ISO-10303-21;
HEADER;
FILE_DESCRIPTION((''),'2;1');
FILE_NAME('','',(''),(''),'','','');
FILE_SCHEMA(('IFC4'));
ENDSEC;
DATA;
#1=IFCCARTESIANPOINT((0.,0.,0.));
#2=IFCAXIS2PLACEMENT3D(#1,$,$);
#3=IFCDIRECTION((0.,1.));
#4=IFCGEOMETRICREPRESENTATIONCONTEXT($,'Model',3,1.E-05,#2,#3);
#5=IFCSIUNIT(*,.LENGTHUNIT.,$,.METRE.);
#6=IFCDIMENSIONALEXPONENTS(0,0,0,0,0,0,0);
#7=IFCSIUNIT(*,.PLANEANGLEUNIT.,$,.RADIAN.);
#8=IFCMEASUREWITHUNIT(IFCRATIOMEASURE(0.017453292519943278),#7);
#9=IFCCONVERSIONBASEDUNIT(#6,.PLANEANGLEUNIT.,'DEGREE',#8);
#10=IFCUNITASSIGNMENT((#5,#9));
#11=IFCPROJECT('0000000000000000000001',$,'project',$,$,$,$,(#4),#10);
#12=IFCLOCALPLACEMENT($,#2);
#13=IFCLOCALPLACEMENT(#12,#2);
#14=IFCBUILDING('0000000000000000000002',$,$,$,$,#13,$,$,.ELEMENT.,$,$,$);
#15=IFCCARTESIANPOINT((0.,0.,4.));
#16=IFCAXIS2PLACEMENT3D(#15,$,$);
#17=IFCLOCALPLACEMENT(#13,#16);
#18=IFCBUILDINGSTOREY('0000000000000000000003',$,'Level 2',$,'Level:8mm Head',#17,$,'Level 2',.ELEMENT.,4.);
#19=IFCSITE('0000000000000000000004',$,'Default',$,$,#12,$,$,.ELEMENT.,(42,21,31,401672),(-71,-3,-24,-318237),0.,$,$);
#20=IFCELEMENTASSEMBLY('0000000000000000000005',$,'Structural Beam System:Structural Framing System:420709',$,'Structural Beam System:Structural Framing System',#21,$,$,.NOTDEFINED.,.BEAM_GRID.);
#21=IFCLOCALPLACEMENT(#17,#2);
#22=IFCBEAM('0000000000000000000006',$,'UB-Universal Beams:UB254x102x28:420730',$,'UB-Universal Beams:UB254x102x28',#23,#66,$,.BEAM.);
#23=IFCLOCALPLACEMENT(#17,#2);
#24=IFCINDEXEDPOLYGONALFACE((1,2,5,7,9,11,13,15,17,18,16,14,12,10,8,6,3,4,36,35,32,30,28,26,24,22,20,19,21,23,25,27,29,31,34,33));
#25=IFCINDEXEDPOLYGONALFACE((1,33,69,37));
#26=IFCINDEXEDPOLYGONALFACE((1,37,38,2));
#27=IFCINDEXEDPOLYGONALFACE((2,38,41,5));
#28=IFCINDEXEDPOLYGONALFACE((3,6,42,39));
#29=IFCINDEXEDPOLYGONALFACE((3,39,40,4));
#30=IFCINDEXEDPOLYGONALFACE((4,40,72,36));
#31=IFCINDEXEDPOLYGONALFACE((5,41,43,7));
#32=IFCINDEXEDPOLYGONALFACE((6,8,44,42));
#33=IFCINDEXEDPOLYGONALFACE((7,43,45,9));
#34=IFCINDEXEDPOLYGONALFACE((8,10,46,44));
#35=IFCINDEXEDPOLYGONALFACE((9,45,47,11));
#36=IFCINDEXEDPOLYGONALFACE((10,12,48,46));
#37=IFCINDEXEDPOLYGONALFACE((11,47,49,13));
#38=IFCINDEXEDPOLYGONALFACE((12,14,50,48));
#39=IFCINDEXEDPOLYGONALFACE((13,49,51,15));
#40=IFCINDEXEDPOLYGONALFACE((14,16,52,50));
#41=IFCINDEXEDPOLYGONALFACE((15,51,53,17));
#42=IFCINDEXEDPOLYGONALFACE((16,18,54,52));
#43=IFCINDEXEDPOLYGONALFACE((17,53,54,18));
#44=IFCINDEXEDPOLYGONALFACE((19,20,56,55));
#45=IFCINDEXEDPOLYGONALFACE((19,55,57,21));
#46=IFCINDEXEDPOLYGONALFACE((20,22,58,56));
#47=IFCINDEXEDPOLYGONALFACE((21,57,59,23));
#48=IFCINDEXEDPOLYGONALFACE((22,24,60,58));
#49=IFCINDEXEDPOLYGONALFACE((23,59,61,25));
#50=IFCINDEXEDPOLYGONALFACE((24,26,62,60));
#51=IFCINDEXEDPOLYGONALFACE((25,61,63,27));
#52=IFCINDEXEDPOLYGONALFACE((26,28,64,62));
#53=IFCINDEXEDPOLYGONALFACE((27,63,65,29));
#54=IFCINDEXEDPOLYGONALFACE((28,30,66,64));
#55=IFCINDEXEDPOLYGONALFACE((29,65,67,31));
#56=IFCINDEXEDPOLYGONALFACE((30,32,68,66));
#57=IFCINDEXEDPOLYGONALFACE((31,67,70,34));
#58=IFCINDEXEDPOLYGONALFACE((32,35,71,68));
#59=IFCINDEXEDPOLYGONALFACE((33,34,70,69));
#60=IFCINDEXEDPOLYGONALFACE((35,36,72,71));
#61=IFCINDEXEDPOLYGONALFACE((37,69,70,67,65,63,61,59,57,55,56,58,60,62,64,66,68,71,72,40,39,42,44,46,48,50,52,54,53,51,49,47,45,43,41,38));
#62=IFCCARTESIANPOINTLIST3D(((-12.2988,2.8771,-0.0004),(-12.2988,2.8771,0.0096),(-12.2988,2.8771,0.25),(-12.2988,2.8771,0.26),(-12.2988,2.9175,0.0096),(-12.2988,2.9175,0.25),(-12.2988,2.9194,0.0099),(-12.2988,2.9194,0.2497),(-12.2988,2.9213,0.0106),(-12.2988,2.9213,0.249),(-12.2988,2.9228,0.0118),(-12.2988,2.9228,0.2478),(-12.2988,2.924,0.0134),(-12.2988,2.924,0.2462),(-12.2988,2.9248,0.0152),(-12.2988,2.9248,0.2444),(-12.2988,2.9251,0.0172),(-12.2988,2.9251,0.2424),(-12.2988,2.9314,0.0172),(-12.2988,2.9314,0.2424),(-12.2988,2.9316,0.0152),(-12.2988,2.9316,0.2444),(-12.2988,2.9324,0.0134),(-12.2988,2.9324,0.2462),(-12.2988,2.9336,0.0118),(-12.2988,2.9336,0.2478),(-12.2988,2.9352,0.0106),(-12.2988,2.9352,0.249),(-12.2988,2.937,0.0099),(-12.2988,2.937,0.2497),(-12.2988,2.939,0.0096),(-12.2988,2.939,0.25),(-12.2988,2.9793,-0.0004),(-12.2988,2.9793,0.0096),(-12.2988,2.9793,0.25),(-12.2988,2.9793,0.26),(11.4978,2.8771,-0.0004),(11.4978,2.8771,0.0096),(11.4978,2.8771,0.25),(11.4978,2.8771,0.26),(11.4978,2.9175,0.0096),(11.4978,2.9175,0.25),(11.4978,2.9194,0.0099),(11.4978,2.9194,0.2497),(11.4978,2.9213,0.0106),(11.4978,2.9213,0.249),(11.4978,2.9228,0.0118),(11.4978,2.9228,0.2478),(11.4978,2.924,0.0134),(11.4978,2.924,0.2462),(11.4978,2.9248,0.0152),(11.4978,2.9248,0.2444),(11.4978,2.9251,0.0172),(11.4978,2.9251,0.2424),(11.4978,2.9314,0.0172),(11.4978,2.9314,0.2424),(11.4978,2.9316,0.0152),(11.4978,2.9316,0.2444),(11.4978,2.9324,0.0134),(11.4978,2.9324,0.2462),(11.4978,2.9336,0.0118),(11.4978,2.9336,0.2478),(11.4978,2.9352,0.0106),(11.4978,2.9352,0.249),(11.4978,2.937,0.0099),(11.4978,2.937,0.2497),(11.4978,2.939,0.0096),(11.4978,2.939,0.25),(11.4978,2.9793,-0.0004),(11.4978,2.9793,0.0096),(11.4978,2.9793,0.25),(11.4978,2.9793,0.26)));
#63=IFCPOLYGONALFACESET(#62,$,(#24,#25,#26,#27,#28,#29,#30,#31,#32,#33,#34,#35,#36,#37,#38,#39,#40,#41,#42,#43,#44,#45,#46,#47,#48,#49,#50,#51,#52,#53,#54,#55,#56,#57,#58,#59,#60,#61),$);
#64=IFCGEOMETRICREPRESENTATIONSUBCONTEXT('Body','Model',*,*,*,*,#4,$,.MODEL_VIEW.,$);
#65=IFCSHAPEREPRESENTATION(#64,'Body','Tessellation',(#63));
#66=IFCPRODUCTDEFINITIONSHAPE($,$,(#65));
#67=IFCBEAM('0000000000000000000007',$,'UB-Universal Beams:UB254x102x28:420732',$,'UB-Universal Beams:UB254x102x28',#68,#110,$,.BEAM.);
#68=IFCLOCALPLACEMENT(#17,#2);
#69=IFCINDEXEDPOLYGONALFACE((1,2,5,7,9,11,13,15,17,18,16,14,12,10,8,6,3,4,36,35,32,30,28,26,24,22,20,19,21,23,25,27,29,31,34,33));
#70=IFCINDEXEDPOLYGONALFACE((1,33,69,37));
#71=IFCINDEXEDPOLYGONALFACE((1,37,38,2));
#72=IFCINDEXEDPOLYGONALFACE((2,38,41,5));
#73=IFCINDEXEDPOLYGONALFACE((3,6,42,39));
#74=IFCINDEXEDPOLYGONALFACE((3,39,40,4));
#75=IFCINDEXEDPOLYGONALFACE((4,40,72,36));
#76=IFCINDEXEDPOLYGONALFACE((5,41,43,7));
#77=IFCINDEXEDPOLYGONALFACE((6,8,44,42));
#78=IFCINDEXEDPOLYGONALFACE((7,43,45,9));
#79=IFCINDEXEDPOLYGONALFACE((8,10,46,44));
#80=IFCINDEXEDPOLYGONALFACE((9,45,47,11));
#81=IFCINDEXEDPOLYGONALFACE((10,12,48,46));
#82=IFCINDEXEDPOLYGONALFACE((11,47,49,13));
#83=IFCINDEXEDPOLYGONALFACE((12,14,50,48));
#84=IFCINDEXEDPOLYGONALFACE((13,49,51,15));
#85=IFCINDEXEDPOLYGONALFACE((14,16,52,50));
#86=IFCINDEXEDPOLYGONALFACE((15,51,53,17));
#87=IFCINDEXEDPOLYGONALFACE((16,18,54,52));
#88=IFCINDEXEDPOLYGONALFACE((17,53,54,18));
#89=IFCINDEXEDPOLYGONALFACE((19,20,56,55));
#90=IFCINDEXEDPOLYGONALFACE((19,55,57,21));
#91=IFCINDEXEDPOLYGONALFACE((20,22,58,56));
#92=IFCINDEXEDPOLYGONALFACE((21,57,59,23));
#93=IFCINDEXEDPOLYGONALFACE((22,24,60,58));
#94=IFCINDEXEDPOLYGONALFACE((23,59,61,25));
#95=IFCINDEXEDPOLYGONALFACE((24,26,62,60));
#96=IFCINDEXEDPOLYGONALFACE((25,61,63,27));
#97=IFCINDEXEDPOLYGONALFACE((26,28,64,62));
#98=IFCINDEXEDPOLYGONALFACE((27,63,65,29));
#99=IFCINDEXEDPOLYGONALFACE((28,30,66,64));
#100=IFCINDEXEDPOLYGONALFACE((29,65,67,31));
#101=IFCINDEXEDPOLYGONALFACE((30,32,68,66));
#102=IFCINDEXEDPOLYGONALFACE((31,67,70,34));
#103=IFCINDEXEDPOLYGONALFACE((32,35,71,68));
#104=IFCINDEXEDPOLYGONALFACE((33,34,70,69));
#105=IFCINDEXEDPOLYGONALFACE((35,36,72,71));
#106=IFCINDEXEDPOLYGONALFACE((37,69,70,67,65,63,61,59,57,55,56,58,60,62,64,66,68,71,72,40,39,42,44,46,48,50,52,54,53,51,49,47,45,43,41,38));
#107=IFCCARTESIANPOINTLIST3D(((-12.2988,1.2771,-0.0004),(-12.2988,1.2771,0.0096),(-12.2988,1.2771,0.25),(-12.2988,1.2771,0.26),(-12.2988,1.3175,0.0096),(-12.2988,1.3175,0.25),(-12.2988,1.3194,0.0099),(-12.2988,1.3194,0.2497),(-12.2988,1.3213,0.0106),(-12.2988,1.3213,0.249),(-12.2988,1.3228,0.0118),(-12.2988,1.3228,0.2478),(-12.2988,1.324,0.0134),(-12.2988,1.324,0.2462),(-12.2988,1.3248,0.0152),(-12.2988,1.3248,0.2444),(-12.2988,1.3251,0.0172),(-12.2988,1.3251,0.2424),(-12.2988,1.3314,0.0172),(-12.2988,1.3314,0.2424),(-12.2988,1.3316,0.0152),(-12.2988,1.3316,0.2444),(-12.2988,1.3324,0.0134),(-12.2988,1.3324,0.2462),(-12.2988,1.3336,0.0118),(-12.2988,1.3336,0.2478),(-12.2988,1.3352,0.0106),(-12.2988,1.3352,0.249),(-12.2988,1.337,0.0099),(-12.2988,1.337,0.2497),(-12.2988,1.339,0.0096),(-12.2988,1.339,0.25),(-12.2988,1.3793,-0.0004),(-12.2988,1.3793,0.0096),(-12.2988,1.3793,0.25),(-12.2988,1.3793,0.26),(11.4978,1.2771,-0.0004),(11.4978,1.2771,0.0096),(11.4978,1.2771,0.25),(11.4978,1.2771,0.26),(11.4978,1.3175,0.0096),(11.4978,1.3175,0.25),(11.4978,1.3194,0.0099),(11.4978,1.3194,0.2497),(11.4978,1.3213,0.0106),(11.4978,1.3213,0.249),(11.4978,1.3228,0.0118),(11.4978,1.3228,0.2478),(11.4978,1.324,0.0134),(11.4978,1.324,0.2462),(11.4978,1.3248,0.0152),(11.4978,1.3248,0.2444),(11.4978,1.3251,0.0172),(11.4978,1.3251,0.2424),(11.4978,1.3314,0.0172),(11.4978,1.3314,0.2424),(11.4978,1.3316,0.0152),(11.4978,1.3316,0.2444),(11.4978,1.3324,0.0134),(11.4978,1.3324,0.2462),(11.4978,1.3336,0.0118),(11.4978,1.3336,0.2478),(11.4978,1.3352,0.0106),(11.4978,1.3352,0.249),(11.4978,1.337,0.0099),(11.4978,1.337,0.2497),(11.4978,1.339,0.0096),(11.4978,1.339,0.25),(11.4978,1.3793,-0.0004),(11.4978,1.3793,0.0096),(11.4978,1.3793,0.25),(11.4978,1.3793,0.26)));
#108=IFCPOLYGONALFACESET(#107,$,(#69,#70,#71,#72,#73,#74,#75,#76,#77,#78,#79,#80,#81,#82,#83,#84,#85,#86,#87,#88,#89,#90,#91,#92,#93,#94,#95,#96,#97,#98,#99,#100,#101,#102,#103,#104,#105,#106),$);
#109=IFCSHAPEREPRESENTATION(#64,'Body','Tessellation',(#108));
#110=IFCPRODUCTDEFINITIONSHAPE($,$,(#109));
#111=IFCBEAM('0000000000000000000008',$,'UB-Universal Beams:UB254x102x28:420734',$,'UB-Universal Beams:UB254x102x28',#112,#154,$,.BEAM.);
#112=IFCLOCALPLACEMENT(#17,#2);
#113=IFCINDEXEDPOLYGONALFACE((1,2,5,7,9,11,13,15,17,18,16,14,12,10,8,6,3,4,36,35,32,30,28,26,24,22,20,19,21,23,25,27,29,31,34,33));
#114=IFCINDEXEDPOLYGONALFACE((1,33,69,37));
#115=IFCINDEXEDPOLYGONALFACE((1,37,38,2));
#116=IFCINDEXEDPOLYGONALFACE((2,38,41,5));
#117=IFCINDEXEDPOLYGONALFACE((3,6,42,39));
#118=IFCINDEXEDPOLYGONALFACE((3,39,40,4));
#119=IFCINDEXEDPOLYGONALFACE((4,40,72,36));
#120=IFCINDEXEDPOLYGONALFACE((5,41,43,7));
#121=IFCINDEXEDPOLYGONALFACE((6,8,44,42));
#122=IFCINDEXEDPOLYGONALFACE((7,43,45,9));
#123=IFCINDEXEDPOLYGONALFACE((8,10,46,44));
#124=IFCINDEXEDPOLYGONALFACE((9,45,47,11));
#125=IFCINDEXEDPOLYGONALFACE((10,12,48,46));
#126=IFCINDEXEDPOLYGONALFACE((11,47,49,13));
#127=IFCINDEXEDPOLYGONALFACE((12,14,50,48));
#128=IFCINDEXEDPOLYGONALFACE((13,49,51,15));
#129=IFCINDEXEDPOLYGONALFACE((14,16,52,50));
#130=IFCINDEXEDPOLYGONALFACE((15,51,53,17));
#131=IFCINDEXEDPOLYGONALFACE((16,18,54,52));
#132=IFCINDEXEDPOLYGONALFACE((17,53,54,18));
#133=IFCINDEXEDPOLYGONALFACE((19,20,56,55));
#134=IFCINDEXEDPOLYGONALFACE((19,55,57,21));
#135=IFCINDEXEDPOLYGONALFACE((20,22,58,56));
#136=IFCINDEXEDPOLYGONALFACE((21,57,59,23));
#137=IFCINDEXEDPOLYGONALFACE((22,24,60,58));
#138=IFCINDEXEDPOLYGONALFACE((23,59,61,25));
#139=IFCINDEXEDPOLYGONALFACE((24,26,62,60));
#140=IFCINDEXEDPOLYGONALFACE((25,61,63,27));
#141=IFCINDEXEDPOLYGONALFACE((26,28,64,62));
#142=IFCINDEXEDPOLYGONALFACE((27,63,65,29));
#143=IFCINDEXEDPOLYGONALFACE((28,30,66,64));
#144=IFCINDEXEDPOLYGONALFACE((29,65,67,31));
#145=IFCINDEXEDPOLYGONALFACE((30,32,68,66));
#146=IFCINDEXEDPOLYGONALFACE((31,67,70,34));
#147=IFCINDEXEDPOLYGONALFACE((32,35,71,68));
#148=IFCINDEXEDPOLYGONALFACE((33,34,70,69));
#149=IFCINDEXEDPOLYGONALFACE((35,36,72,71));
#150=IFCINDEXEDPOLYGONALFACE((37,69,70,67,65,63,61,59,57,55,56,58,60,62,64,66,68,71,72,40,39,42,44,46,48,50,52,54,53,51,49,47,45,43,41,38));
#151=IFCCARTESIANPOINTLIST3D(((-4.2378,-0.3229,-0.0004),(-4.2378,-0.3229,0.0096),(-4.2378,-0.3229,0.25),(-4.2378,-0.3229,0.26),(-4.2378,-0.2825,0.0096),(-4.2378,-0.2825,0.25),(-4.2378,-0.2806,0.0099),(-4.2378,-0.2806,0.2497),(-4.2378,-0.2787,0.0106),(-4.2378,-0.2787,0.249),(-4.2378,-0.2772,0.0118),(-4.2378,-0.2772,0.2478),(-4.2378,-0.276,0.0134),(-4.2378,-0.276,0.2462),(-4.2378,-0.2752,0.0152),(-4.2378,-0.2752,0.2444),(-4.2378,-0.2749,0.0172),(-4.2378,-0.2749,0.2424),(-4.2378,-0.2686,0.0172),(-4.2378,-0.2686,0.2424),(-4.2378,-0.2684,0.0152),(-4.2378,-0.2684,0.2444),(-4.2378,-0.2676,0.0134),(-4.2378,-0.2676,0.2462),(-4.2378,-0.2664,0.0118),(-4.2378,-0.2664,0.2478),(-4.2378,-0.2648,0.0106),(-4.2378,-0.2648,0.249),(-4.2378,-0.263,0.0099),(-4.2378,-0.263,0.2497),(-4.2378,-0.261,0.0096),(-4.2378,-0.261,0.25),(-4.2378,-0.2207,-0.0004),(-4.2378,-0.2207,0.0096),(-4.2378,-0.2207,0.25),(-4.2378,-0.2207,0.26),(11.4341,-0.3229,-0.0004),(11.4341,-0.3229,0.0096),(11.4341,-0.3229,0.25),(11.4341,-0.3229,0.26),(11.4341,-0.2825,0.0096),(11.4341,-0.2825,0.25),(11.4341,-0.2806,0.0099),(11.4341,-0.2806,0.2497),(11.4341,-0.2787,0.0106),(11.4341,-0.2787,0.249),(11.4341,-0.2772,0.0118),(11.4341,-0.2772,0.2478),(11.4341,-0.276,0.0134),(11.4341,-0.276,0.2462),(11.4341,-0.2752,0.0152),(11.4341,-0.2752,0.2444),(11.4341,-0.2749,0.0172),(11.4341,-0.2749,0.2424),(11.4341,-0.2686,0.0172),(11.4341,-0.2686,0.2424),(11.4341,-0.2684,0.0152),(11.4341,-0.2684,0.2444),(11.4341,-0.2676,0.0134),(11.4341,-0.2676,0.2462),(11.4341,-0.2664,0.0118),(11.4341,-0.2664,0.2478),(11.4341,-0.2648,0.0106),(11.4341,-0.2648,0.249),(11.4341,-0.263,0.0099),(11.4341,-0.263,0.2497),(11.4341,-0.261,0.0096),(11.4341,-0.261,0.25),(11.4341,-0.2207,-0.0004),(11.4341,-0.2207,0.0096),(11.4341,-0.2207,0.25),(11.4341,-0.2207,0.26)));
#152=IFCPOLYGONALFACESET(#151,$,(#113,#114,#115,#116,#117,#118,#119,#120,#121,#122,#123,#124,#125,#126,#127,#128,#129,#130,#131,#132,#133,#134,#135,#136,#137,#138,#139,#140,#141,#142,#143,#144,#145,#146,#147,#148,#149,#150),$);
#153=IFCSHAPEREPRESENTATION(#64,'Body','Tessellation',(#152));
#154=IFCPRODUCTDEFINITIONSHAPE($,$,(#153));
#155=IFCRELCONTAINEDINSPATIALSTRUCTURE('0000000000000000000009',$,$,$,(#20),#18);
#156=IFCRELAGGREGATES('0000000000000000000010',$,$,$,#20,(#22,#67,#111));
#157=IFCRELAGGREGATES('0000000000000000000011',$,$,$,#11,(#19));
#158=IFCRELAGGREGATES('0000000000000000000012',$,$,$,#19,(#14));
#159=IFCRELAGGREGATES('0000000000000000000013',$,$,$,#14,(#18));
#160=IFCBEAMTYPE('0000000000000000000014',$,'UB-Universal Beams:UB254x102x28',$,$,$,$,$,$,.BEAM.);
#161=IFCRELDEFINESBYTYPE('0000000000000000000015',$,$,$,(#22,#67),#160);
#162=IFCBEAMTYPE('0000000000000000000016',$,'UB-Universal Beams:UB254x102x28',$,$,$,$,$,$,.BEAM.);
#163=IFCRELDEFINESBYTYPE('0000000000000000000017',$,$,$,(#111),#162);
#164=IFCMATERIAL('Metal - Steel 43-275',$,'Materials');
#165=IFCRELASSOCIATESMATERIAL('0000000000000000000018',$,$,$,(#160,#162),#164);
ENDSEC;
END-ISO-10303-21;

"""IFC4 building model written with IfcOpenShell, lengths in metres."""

from ifc_helpers import new_model, entity, si_unit, converted_unit, direction, frame, frame_2d, origin, place, context, subcontext, project, spatial, i_section, extrude, source, transform, mapped, material, material_profile, profile_set, type_object, type_shapes, element, aggregate, save


model = new_model("IFC4")

# Units and contexts
model_context = context("Model", 3, precision=1e-05, world=origin(), true_north=direction((0.0, 1.0)))
body_context = subcontext(model_context, "Body", "Model", "MODEL_VIEW")
ifc_project = project(units=[si_unit("LENGTHUNIT", "METRE"), converted_unit("PLANEANGLEUNIT", "DEGREE", entity("IfcRatioMeasure", 0.017453292519943278), si_unit("PLANEANGLEUNIT", "RADIAN"), dimensions=[0, 0, 0, 0, 0, 0, 0])], contexts=[model_context])

# Site, building, storey
site_placement = place(None, origin())
site = spatial("IfcSite", under=ifc_project, at=site_placement, Name="Default", CompositionType="ELEMENT", RefLatitude=(42, 21, 31, 401672), RefLongitude=(-71, -3, -24, -318237), RefElevation=0.0)
building_placement = place(site_placement, origin())
building = spatial("IfcBuilding", under=site, at=building_placement, CompositionType="ELEMENT")
storey_placement = place(building_placement, frame((0.0, 0.0, 4.0)))
storey = spatial("IfcBuildingStorey", under=building, at=storey_placement, Name="Level 2", ObjectType="Level:8mm Head", LongName="Level 2", CompositionType="ELEMENT", Elevation=4.0)

# Shared definitions
ifc_material_1 = material(Name="Metal - Steel 43-275", Category="Materials")

# Element assembly, beams
assembly_placement = place(storey_placement, origin())
assembly = element("IfcElementAssembly", 1, at=assembly_placement, inside=storey, Name="Structural Beam System:Structural Framing System:420709", ObjectType="Structural Beam System:Structural Framing System", AssemblyPlace="NOTDEFINED", PredefinedType="BEAM_GRID")
ifc_material_profile_1 = material_profile(ifc_material_1, i_section(OverallWidth=0.1022, OverallDepth=0.2604, WebThickness=0.0063, FlangeThickness=0.01, FilletRadius=0.0076, at=frame_2d((0.0, 0.0), x_axis=(0.0, 1.0))), Name="UB254x102x28")
ifc_profile_set_1 = profile_set([ifc_material_profile_1], Name="UB254x102x28")
beam_type_1 = type_object("IfcBeamType", Name="UB-Universal Beams:UB254x102x28", PredefinedType="BEAM", material=ifc_profile_set_1)
shared_shape_1 = source(origin(), body_context, "Body", "SweptSolid", [
    extrude(i_section(OverallWidth=0.1022, OverallDepth=0.2604, WebThickness=0.0063, FlangeThickness=0.01, FilletRadius=0.0076, at=frame_2d((0.0, 0.0), x_axis=(0.0, 1.0))), frame((-11.8983, 0.0, 0.0), z_axis=(1.0, 0.0, 0.0), x_axis=(0.0, 0.0, -1.0)), (0.0, 0.0, 1.0), 23.7966),
])
type_shapes(beam_type_1, [shared_shape_1])
beam_1_placement = place(assembly_placement, frame((-0.4005, 2.9282, 0.1298)))
beam_1 = element("IfcBeam", 2, at=beam_1_placement, type_object=beam_type_1, Name="UB-Universal Beams:UB254x102x28:420730", ObjectType="UB-Universal Beams:UB254x102x28", PredefinedType="BEAM", context=body_context, shape_type="MappedRepresentation", body=[
    mapped(shared_shape_1, transform((0.0, 0.0, 0.0), scale=1.0)),
])
beam_2_placement = place(assembly_placement, frame((-0.4005, 1.3282, 0.1298)))
beam_2 = element("IfcBeam", 3, at=beam_2_placement, type_object=beam_type_1, Name="UB-Universal Beams:UB254x102x28:420732", ObjectType="UB-Universal Beams:UB254x102x28", PredefinedType="BEAM", context=body_context, shape_type="MappedRepresentation", body=[
    mapped(shared_shape_1, transform((0.0, 0.0, 0.0), scale=1.0)),
])
beam_type_2 = type_object("IfcBeamType", Name="UB-Universal Beams:UB254x102x28", PredefinedType="BEAM", material=ifc_profile_set_1)
shared_shape_2 = source(origin(), body_context, "Body", "SweptSolid", [
    extrude(i_section(OverallWidth=0.1022, OverallDepth=0.2604, WebThickness=0.0063, FlangeThickness=0.01, FilletRadius=0.0076, at=frame_2d((0.0, 0.0), x_axis=(0.0, 1.0))), frame((-7.8818, 0.0, 0.0), z_axis=(1.0, 0.0, 0.0), x_axis=(0.0, 0.0, -1.0)), (0.0, 0.0, 1.0), 15.6719),
])
type_shapes(beam_type_2, [shared_shape_2])
beam_3_placement = place(assembly_placement, frame((3.644, -0.2718, 0.1298)))
beam_3 = element("IfcBeam", 4, at=beam_3_placement, type_object=beam_type_2, Name="UB-Universal Beams:UB254x102x28:420734", ObjectType="UB-Universal Beams:UB254x102x28", PredefinedType="BEAM", context=body_context, shape_type="MappedRepresentation", body=[
    mapped(shared_shape_2, transform((0.0, 0.0, 0.0), scale=1.0)),
])
aggregate(assembly, [beam_1, beam_2, beam_3])

save(model, "model.ifc")
